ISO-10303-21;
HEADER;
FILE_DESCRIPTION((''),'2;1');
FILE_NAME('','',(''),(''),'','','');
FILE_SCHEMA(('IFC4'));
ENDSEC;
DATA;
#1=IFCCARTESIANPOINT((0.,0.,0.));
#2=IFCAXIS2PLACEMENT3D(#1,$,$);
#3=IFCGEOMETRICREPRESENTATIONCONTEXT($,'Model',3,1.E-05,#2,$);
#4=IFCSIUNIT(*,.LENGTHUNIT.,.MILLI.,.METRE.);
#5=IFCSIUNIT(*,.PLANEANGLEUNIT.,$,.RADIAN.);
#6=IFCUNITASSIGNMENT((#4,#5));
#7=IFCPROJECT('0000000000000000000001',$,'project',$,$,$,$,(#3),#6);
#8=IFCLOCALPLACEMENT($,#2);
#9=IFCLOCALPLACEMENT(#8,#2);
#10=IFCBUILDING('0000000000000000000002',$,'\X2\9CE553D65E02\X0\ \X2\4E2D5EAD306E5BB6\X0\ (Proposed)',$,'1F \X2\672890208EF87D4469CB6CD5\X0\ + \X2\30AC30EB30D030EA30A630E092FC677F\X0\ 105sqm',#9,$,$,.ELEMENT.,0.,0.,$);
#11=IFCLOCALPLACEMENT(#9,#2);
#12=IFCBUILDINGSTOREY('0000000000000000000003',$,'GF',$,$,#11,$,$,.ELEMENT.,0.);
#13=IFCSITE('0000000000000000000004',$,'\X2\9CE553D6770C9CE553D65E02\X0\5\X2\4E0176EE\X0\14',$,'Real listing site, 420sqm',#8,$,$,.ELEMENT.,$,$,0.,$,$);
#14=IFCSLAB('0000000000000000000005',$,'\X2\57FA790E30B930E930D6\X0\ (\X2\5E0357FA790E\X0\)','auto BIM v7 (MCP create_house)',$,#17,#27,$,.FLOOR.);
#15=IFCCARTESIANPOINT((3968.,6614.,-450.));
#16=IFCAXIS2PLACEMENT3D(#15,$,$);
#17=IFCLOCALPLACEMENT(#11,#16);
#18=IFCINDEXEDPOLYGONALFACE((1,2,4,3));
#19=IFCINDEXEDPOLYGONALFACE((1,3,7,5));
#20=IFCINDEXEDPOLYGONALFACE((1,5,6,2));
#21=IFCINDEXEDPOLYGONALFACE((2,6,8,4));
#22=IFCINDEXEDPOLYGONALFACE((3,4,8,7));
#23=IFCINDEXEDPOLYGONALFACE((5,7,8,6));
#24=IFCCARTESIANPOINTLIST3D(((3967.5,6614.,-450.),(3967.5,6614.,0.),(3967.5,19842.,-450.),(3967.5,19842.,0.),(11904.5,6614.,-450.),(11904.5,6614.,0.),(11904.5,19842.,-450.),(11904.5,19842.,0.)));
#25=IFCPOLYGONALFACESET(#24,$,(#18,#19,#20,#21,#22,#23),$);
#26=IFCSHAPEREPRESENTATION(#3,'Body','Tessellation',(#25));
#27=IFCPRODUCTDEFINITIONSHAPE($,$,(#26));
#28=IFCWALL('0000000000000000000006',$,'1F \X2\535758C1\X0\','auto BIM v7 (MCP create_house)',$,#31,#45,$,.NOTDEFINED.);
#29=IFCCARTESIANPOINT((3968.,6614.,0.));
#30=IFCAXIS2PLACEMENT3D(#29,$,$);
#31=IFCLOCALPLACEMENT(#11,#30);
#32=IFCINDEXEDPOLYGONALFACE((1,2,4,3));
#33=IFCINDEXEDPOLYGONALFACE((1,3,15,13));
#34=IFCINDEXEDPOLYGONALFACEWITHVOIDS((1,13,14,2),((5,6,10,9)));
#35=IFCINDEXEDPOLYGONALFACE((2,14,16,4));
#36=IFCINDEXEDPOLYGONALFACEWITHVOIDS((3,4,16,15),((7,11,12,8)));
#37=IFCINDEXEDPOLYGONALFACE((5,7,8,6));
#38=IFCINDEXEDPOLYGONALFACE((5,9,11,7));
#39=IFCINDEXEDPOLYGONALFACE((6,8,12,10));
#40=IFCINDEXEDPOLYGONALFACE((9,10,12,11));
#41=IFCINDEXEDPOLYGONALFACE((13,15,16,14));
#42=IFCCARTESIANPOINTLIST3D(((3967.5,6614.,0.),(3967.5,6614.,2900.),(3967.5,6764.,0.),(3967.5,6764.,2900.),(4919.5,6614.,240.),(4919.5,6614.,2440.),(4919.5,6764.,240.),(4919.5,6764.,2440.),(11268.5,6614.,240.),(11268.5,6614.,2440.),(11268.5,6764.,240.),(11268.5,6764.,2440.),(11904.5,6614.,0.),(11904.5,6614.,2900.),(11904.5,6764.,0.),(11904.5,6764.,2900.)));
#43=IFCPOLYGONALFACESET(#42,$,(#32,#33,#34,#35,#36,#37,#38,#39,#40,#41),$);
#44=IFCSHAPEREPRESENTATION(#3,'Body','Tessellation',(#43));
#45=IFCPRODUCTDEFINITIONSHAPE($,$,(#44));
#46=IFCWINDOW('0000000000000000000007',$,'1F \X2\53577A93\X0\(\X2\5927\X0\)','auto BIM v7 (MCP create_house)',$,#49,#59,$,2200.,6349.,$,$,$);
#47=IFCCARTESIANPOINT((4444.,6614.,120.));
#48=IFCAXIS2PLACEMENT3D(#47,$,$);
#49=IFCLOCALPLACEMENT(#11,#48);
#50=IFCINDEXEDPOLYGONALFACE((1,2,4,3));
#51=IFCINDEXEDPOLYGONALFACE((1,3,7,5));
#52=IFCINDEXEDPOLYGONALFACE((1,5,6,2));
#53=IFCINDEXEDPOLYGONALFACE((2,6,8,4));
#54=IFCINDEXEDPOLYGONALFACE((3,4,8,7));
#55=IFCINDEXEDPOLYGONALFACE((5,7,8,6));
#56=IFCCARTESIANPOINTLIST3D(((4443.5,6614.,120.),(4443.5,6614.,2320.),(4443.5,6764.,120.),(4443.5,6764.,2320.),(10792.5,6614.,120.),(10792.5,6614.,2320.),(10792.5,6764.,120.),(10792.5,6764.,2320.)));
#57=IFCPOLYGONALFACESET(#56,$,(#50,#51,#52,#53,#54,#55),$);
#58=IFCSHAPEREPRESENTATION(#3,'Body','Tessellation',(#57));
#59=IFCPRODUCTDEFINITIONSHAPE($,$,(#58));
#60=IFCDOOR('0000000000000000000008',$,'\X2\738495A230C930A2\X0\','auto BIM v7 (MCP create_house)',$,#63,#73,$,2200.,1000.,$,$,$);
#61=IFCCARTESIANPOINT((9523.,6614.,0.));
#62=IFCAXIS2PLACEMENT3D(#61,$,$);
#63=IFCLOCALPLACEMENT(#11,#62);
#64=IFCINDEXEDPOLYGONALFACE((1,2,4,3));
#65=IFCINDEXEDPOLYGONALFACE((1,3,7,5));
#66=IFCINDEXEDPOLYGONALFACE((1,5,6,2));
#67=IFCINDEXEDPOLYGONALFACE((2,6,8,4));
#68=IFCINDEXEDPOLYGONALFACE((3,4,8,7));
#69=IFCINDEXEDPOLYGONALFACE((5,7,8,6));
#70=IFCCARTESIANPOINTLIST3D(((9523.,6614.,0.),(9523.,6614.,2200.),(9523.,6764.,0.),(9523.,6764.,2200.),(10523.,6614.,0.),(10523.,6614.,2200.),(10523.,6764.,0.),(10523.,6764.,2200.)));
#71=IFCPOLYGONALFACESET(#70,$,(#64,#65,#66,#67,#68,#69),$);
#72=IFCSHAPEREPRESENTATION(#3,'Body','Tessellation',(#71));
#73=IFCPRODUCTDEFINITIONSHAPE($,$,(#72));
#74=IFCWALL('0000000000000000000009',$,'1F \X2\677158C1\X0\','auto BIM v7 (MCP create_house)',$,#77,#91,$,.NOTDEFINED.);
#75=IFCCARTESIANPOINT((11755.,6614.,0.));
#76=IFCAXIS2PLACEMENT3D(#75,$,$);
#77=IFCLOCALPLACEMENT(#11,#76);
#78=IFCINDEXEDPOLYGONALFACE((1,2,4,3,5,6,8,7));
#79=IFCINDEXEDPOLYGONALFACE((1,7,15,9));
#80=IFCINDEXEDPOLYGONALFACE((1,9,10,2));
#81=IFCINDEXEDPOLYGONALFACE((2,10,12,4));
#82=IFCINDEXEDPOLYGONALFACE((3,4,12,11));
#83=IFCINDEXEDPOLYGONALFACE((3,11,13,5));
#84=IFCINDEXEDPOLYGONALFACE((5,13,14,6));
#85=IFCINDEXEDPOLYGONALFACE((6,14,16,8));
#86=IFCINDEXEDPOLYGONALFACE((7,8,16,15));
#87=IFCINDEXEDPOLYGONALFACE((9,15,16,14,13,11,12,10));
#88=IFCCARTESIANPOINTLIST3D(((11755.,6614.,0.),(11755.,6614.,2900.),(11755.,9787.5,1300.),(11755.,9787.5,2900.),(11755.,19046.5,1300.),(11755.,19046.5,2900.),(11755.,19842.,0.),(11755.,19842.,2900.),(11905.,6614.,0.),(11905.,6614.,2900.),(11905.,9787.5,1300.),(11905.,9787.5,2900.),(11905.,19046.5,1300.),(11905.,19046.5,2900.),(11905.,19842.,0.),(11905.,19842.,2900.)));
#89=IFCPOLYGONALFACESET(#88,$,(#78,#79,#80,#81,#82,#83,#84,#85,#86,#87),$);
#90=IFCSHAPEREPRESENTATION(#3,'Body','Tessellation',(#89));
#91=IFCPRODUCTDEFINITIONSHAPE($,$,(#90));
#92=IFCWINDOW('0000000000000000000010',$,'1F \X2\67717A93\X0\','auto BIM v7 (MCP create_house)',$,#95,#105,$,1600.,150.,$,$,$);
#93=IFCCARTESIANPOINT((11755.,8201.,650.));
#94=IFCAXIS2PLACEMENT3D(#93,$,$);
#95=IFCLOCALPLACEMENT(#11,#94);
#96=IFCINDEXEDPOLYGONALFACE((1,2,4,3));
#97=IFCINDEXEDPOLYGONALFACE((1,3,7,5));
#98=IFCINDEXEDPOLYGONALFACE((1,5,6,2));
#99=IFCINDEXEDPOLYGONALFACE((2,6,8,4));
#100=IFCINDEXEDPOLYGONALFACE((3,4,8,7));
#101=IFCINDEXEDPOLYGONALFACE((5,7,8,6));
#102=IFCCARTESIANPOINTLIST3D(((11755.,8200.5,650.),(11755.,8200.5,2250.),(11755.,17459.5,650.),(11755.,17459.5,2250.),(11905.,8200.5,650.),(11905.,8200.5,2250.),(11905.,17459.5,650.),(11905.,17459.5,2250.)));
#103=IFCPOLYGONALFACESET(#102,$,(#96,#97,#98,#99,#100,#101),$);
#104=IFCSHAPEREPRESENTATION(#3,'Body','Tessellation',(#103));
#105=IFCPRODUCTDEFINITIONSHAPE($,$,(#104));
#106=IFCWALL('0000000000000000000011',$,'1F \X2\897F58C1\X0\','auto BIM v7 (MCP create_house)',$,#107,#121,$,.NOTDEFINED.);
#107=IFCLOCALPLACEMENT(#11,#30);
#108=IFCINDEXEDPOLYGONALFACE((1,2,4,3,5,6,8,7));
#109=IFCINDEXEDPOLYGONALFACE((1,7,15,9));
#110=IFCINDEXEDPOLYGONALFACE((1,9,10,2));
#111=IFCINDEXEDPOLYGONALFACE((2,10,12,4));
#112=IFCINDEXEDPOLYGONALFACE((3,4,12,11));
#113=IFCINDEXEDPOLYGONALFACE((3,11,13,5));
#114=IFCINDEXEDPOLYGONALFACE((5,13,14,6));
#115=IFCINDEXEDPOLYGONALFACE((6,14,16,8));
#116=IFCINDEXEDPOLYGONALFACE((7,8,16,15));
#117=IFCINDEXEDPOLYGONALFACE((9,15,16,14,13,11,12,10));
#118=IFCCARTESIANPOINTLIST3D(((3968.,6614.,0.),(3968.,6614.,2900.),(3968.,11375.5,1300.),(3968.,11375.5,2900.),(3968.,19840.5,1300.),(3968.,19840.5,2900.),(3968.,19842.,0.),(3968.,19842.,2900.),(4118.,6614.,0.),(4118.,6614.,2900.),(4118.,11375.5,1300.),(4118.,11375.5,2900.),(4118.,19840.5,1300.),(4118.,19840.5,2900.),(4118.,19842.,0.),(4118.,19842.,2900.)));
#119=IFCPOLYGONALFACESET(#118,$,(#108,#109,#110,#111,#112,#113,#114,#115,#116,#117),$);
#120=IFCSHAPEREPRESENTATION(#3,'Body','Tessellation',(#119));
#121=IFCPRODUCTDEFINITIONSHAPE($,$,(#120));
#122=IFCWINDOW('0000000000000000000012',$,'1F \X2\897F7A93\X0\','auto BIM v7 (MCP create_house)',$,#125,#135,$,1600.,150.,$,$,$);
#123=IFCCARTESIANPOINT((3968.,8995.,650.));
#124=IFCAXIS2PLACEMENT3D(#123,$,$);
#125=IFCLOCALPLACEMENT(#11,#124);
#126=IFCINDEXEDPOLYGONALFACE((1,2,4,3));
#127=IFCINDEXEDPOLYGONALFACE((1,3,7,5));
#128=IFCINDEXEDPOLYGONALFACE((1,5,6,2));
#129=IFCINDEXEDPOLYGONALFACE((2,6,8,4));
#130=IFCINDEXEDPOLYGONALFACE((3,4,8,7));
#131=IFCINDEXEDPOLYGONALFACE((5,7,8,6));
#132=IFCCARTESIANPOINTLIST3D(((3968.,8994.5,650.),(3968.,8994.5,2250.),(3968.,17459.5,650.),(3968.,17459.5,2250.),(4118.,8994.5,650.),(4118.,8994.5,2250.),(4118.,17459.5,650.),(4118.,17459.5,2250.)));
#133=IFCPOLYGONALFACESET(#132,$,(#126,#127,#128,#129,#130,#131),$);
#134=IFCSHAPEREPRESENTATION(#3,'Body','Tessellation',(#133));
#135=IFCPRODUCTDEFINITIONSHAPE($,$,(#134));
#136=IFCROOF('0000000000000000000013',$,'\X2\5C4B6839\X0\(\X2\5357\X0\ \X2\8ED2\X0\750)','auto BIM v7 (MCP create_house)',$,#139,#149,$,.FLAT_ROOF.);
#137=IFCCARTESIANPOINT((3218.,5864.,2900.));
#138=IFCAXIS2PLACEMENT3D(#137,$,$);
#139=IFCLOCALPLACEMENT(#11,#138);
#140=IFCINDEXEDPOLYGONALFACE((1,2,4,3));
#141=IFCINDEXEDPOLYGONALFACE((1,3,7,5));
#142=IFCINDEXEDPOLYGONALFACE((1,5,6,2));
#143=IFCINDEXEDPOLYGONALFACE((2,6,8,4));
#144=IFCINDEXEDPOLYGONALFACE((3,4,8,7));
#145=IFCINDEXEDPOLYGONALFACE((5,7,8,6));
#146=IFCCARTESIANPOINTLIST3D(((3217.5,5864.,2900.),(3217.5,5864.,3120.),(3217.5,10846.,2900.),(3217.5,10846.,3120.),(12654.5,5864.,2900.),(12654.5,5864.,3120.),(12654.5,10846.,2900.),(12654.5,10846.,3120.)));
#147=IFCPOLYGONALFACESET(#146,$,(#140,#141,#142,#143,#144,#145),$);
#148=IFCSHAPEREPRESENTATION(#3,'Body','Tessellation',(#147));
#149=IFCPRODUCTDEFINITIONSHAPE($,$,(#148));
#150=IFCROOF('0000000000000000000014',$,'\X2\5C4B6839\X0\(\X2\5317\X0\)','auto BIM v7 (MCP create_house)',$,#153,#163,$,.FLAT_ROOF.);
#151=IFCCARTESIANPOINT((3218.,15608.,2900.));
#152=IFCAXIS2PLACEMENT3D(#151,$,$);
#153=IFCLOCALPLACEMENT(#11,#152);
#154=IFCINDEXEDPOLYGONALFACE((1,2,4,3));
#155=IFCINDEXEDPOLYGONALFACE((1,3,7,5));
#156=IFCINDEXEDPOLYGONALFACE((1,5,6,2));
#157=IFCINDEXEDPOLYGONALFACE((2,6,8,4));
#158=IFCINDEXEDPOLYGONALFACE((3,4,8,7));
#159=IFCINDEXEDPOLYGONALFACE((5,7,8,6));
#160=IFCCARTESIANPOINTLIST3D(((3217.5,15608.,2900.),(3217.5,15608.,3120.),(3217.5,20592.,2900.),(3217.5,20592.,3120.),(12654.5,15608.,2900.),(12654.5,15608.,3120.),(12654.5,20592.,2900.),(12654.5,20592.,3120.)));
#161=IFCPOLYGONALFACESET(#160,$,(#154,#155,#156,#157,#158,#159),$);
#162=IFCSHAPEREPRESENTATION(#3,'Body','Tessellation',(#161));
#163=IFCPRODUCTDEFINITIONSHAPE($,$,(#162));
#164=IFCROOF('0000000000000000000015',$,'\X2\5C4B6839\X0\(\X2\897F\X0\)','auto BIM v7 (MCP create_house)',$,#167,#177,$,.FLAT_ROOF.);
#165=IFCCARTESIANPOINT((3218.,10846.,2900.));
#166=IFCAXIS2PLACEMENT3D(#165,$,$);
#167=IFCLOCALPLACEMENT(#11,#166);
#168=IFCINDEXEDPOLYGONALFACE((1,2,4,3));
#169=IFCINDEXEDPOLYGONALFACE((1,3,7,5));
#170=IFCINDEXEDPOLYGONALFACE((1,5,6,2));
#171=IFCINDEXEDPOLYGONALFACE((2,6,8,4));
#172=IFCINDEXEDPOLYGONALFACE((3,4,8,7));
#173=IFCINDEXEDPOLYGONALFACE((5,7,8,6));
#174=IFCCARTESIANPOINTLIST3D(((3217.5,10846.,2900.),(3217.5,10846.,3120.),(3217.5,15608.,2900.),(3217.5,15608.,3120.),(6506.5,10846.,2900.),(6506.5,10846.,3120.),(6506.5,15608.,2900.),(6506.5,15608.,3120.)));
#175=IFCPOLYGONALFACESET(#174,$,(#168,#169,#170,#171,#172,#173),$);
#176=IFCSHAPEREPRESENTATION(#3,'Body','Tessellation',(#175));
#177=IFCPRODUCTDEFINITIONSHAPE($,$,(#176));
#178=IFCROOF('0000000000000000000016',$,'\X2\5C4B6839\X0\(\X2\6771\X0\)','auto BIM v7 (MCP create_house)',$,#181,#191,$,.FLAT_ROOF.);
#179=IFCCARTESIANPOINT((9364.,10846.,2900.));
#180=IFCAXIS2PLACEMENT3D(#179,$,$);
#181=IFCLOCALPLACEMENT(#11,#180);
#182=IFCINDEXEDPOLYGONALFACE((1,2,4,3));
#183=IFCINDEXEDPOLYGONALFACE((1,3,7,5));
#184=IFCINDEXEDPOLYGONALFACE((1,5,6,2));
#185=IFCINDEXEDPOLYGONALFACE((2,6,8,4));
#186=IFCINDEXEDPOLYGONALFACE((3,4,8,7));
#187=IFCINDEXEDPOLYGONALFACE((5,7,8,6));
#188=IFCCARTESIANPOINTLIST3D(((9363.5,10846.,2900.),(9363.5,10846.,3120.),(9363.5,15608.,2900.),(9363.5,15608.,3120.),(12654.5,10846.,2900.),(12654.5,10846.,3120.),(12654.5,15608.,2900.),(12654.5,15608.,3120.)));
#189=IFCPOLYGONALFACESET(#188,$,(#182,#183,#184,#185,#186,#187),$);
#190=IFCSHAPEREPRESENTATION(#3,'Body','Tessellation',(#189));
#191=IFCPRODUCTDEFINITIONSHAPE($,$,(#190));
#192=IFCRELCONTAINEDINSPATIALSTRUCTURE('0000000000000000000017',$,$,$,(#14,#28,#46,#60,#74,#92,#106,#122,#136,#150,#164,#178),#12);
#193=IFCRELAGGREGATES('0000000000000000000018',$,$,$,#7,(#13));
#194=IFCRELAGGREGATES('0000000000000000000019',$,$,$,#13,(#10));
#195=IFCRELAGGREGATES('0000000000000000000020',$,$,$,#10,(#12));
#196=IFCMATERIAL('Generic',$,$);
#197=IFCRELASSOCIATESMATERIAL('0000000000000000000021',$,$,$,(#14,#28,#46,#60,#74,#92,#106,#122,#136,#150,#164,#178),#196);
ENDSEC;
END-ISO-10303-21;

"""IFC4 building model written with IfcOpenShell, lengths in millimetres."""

from ifc_helpers import new_model, si_unit, frame, frame_2d, origin, place, context, project, spatial, rectangle, extrude, material, element, fill, save


model = new_model("IFC4")

# Units and contexts
model_context = context("Model", 3, precision=1e-05, world=origin())
ifc_project = project(units=[si_unit("LENGTHUNIT", "METRE", prefix="MILLI"), si_unit("PLANEANGLEUNIT", "RADIAN")], contexts=[model_context])

# Site, building, storey
site_placement = place(None, origin())
site = spatial("IfcSite", under=ifc_project, at=site_placement, Name="鳥取県鳥取市5丁目14", ObjectType="Real listing site, 420sqm", CompositionType="ELEMENT", RefElevation=0.0)
building_placement = place(site_placement, origin())
building = spatial("IfcBuilding", under=site, at=building_placement, Name="鳥取市 中庭の家 (Proposed)", ObjectType="1F 木造軸組構法 + ガルバリウム鋼板 105sqm", CompositionType="ELEMENT", ElevationOfRefHeight=0.0, ElevationOfTerrain=0.0)
storey_placement = place(building_placement, origin())
storey = spatial("IfcBuildingStorey", under=building, at=storey_placement, Name="GF", CompositionType="ELEMENT", Elevation=0.0)

# Slab
ifc_material = material(Name="Generic")
slab_1_placement = place(storey_placement, frame((3968.0, 6614.0, -450.0)))
element("IfcSlab", 1, at=slab_1_placement, inside=storey, material=ifc_material, Name="基礎スラブ (布基礎)", Description="auto BIM v7 (MCP create_house)", PredefinedType="FLOOR", context=model_context, shape_type="SweptSolid", body=[
    extrude(rectangle(XDim=7937.0, YDim=13228.0, at=frame_2d((3968.0, 6614.0))), frame((3968.0, 6614.0, -450.0)), (0.0, 0.0, 1.0), 450.0),
])

# Wall, openings, window, door
wall_1_placement = place(storey_placement, frame((3968.0, 6614.0, 0.0)))
wall_1 = element("IfcWall", 2, at=wall_1_placement, inside=storey, material=ifc_material, Name="1F 南壁", Description="auto BIM v7 (MCP create_house)", PredefinedType="NOTDEFINED", context=model_context, shape_type="SweptSolid", body=[
    extrude(rectangle(XDim=7937.0, YDim=150.0, at=frame_2d((3968.0, 75.0))), frame((3968.0, 6614.0, 0.0)), (0.0, 0.0, 1.0), 2900.0),
])
opening_1_placement = place(storey_placement, frame((4444.0, 6614.0, 120.0)))
opening_1 = element("IfcOpeningElement", 3, at=opening_1_placement, cuts=wall_1, PredefinedType="NOTDEFINED", context=model_context, shape_type="SweptSolid", body=[
    extrude(rectangle(XDim=6349.0, YDim=150.0, at=frame_2d((3174.0, 75.0))), frame((4444.0, 6614.0, 120.0)), (0.0, 0.0, 1.0), 2200.0),
])
opening_2_placement = place(storey_placement, frame((9523.0, 6614.0, 0.0)))
opening_2 = element("IfcOpeningElement", 4, at=opening_2_placement, cuts=wall_1, PredefinedType="NOTDEFINED", context=model_context, shape_type="SweptSolid", body=[
    extrude(rectangle(XDim=1000.0, YDim=150.0, at=frame_2d((500.0, 75.0))), frame((9523.0, 6614.0, 0.0)), (0.0, 0.0, 1.0), 2200.0),
])
window_1_placement = place(storey_placement, frame((4444.0, 6614.0, 120.0)))
window_1 = element("IfcWindow", 5, at=window_1_placement, inside=storey, material=ifc_material, Name="1F 南窓(大)", Description="auto BIM v7 (MCP create_house)", OverallHeight=2200.0, OverallWidth=6349.0, context=model_context, shape_type="SweptSolid", body=[
    extrude(rectangle(XDim=6349.0, YDim=150.0, at=frame_2d((3174.0, 75.0))), frame((4444.0, 6614.0, 120.0)), (0.0, 0.0, 1.0), 2200.0),
])
fill(opening_1, window_1)
door_placement = place(storey_placement, frame((9523.0, 6614.0, 0.0)))
door = element("IfcDoor", 6, at=door_placement, inside=storey, material=ifc_material, Name="玄関ドア", Description="auto BIM v7 (MCP create_house)", OverallHeight=2200.0, OverallWidth=1000.0, context=model_context, shape_type="SweptSolid", body=[
    extrude(rectangle(XDim=1000.0, YDim=150.0, at=frame_2d((500.0, 75.0))), frame((9523.0, 6614.0, 0.0)), (0.0, 0.0, 1.0), 2200.0),
])
fill(opening_2, door)

# Walls, openings, windows
wall_2_placement = place(storey_placement, frame((11755.0, 6614.0, 0.0)))
wall_2 = element("IfcWall", 7, at=wall_2_placement, inside=storey, material=ifc_material, Name="1F 東壁", Description="auto BIM v7 (MCP create_house)", PredefinedType="NOTDEFINED", context=model_context, shape_type="SweptSolid", body=[
    extrude(rectangle(XDim=150.0, YDim=13228.0, at=frame_2d((75.0, 6614.0))), frame((11755.0, 6614.0, 0.0)), (0.0, 0.0, 1.0), 2900.0),
])
opening_3_placement = place(storey_placement, frame((11755.0, 8201.0, 650.0)))
opening_3 = element("IfcOpeningElement", 8, at=opening_3_placement, cuts=wall_2, PredefinedType="NOTDEFINED", context=model_context, shape_type="SweptSolid", body=[
    extrude(rectangle(XDim=150.0, YDim=9259.0, at=frame_2d((75.0, 4629.0))), frame((11755.0, 8201.0, 650.0)), (0.0, 0.0, 1.0), 1600.0),
])
window_2_placement = place(storey_placement, frame((11755.0, 8201.0, 650.0)))
window_2 = element("IfcWindow", 9, at=window_2_placement, inside=storey, material=ifc_material, Name="1F 東窓", Description="auto BIM v7 (MCP create_house)", OverallHeight=1600.0, OverallWidth=150.0, context=model_context, shape_type="SweptSolid", body=[
    extrude(rectangle(XDim=150.0, YDim=9259.0, at=frame_2d((75.0, 4629.0))), frame((11755.0, 8201.0, 650.0)), (0.0, 0.0, 1.0), 1600.0),
])
fill(opening_3, window_2)
wall_3_placement = place(storey_placement, frame((3968.0, 6614.0, 0.0)))
wall_3 = element("IfcWall", 10, at=wall_3_placement, inside=storey, material=ifc_material, Name="1F 西壁", Description="auto BIM v7 (MCP create_house)", PredefinedType="NOTDEFINED", context=model_context, shape_type="SweptSolid", body=[
    extrude(rectangle(XDim=150.0, YDim=13228.0, at=frame_2d((75.0, 6614.0))), frame((3968.0, 6614.0, 0.0)), (0.0, 0.0, 1.0), 2900.0),
])
opening_4_placement = place(storey_placement, frame((3968.0, 8995.0, 650.0)))
opening_4 = element("IfcOpeningElement", 11, at=opening_4_placement, cuts=wall_3, PredefinedType="NOTDEFINED", context=model_context, shape_type="SweptSolid", body=[
    extrude(rectangle(XDim=150.0, YDim=8465.0, at=frame_2d((75.0, 4232.0))), frame((3968.0, 8995.0, 650.0)), (0.0, 0.0, 1.0), 1600.0),
])
window_3_placement = place(storey_placement, frame((3968.0, 8995.0, 650.0)))
window_3 = element("IfcWindow", 12, at=window_3_placement, inside=storey, material=ifc_material, Name="1F 西窓", Description="auto BIM v7 (MCP create_house)", OverallHeight=1600.0, OverallWidth=150.0, context=model_context, shape_type="SweptSolid", body=[
    extrude(rectangle(XDim=150.0, YDim=8465.0, at=frame_2d((75.0, 4232.0))), frame((3968.0, 8995.0, 650.0)), (0.0, 0.0, 1.0), 1600.0),
])
fill(opening_4, window_3)

# Roofs
roof_1_placement = place(storey_placement, frame((3218.0, 5864.0, 2900.0)))
element("IfcRoof", 13, at=roof_1_placement, inside=storey, material=ifc_material, Name="屋根(南 軒750)", Description="auto BIM v7 (MCP create_house)", PredefinedType="FLAT_ROOF", context=model_context, shape_type="SweptSolid", body=[
    extrude(rectangle(XDim=9437.0, YDim=4982.0, at=frame_2d((4718.0, 2491.0))), frame((3218.0, 5864.0, 2900.0)), (0.0, 0.0, 1.0), 220.0),
])
roof_2_placement = place(storey_placement, frame((3218.0, 15608.0, 2900.0)))
element("IfcRoof", 14, at=roof_2_placement, inside=storey, material=ifc_material, Name="屋根(北)", Description="auto BIM v7 (MCP create_house)", PredefinedType="FLAT_ROOF", context=model_context, shape_type="SweptSolid", body=[
    extrude(rectangle(XDim=9437.0, YDim=4984.0, at=frame_2d((4718.0, 2492.0))), frame((3218.0, 15608.0, 2900.0)), (0.0, 0.0, 1.0), 220.0),
])
roof_3_placement = place(storey_placement, frame((3218.0, 10846.0, 2900.0)))
element("IfcRoof", 15, at=roof_3_placement, inside=storey, material=ifc_material, Name="屋根(西)", Description="auto BIM v7 (MCP create_house)", PredefinedType="FLAT_ROOF", context=model_context, shape_type="SweptSolid", body=[
    extrude(rectangle(XDim=3289.0, YDim=4762.0, at=frame_2d((1644.0, 2381.0))), frame((3218.0, 10846.0, 2900.0)), (0.0, 0.0, 1.0), 220.0),
])
roof_4_placement = place(storey_placement, frame((9364.0, 10846.0, 2900.0)))
element("IfcRoof", 16, at=roof_4_placement, inside=storey, material=ifc_material, Name="屋根(東)", Description="auto BIM v7 (MCP create_house)", PredefinedType="FLAT_ROOF", context=model_context, shape_type="SweptSolid", body=[
    extrude(rectangle(XDim=3291.0, YDim=4762.0, at=frame_2d((1645.0, 2381.0))), frame((9364.0, 10846.0, 2900.0)), (0.0, 0.0, 1.0), 220.0),
])

save(model, "model.ifc")
